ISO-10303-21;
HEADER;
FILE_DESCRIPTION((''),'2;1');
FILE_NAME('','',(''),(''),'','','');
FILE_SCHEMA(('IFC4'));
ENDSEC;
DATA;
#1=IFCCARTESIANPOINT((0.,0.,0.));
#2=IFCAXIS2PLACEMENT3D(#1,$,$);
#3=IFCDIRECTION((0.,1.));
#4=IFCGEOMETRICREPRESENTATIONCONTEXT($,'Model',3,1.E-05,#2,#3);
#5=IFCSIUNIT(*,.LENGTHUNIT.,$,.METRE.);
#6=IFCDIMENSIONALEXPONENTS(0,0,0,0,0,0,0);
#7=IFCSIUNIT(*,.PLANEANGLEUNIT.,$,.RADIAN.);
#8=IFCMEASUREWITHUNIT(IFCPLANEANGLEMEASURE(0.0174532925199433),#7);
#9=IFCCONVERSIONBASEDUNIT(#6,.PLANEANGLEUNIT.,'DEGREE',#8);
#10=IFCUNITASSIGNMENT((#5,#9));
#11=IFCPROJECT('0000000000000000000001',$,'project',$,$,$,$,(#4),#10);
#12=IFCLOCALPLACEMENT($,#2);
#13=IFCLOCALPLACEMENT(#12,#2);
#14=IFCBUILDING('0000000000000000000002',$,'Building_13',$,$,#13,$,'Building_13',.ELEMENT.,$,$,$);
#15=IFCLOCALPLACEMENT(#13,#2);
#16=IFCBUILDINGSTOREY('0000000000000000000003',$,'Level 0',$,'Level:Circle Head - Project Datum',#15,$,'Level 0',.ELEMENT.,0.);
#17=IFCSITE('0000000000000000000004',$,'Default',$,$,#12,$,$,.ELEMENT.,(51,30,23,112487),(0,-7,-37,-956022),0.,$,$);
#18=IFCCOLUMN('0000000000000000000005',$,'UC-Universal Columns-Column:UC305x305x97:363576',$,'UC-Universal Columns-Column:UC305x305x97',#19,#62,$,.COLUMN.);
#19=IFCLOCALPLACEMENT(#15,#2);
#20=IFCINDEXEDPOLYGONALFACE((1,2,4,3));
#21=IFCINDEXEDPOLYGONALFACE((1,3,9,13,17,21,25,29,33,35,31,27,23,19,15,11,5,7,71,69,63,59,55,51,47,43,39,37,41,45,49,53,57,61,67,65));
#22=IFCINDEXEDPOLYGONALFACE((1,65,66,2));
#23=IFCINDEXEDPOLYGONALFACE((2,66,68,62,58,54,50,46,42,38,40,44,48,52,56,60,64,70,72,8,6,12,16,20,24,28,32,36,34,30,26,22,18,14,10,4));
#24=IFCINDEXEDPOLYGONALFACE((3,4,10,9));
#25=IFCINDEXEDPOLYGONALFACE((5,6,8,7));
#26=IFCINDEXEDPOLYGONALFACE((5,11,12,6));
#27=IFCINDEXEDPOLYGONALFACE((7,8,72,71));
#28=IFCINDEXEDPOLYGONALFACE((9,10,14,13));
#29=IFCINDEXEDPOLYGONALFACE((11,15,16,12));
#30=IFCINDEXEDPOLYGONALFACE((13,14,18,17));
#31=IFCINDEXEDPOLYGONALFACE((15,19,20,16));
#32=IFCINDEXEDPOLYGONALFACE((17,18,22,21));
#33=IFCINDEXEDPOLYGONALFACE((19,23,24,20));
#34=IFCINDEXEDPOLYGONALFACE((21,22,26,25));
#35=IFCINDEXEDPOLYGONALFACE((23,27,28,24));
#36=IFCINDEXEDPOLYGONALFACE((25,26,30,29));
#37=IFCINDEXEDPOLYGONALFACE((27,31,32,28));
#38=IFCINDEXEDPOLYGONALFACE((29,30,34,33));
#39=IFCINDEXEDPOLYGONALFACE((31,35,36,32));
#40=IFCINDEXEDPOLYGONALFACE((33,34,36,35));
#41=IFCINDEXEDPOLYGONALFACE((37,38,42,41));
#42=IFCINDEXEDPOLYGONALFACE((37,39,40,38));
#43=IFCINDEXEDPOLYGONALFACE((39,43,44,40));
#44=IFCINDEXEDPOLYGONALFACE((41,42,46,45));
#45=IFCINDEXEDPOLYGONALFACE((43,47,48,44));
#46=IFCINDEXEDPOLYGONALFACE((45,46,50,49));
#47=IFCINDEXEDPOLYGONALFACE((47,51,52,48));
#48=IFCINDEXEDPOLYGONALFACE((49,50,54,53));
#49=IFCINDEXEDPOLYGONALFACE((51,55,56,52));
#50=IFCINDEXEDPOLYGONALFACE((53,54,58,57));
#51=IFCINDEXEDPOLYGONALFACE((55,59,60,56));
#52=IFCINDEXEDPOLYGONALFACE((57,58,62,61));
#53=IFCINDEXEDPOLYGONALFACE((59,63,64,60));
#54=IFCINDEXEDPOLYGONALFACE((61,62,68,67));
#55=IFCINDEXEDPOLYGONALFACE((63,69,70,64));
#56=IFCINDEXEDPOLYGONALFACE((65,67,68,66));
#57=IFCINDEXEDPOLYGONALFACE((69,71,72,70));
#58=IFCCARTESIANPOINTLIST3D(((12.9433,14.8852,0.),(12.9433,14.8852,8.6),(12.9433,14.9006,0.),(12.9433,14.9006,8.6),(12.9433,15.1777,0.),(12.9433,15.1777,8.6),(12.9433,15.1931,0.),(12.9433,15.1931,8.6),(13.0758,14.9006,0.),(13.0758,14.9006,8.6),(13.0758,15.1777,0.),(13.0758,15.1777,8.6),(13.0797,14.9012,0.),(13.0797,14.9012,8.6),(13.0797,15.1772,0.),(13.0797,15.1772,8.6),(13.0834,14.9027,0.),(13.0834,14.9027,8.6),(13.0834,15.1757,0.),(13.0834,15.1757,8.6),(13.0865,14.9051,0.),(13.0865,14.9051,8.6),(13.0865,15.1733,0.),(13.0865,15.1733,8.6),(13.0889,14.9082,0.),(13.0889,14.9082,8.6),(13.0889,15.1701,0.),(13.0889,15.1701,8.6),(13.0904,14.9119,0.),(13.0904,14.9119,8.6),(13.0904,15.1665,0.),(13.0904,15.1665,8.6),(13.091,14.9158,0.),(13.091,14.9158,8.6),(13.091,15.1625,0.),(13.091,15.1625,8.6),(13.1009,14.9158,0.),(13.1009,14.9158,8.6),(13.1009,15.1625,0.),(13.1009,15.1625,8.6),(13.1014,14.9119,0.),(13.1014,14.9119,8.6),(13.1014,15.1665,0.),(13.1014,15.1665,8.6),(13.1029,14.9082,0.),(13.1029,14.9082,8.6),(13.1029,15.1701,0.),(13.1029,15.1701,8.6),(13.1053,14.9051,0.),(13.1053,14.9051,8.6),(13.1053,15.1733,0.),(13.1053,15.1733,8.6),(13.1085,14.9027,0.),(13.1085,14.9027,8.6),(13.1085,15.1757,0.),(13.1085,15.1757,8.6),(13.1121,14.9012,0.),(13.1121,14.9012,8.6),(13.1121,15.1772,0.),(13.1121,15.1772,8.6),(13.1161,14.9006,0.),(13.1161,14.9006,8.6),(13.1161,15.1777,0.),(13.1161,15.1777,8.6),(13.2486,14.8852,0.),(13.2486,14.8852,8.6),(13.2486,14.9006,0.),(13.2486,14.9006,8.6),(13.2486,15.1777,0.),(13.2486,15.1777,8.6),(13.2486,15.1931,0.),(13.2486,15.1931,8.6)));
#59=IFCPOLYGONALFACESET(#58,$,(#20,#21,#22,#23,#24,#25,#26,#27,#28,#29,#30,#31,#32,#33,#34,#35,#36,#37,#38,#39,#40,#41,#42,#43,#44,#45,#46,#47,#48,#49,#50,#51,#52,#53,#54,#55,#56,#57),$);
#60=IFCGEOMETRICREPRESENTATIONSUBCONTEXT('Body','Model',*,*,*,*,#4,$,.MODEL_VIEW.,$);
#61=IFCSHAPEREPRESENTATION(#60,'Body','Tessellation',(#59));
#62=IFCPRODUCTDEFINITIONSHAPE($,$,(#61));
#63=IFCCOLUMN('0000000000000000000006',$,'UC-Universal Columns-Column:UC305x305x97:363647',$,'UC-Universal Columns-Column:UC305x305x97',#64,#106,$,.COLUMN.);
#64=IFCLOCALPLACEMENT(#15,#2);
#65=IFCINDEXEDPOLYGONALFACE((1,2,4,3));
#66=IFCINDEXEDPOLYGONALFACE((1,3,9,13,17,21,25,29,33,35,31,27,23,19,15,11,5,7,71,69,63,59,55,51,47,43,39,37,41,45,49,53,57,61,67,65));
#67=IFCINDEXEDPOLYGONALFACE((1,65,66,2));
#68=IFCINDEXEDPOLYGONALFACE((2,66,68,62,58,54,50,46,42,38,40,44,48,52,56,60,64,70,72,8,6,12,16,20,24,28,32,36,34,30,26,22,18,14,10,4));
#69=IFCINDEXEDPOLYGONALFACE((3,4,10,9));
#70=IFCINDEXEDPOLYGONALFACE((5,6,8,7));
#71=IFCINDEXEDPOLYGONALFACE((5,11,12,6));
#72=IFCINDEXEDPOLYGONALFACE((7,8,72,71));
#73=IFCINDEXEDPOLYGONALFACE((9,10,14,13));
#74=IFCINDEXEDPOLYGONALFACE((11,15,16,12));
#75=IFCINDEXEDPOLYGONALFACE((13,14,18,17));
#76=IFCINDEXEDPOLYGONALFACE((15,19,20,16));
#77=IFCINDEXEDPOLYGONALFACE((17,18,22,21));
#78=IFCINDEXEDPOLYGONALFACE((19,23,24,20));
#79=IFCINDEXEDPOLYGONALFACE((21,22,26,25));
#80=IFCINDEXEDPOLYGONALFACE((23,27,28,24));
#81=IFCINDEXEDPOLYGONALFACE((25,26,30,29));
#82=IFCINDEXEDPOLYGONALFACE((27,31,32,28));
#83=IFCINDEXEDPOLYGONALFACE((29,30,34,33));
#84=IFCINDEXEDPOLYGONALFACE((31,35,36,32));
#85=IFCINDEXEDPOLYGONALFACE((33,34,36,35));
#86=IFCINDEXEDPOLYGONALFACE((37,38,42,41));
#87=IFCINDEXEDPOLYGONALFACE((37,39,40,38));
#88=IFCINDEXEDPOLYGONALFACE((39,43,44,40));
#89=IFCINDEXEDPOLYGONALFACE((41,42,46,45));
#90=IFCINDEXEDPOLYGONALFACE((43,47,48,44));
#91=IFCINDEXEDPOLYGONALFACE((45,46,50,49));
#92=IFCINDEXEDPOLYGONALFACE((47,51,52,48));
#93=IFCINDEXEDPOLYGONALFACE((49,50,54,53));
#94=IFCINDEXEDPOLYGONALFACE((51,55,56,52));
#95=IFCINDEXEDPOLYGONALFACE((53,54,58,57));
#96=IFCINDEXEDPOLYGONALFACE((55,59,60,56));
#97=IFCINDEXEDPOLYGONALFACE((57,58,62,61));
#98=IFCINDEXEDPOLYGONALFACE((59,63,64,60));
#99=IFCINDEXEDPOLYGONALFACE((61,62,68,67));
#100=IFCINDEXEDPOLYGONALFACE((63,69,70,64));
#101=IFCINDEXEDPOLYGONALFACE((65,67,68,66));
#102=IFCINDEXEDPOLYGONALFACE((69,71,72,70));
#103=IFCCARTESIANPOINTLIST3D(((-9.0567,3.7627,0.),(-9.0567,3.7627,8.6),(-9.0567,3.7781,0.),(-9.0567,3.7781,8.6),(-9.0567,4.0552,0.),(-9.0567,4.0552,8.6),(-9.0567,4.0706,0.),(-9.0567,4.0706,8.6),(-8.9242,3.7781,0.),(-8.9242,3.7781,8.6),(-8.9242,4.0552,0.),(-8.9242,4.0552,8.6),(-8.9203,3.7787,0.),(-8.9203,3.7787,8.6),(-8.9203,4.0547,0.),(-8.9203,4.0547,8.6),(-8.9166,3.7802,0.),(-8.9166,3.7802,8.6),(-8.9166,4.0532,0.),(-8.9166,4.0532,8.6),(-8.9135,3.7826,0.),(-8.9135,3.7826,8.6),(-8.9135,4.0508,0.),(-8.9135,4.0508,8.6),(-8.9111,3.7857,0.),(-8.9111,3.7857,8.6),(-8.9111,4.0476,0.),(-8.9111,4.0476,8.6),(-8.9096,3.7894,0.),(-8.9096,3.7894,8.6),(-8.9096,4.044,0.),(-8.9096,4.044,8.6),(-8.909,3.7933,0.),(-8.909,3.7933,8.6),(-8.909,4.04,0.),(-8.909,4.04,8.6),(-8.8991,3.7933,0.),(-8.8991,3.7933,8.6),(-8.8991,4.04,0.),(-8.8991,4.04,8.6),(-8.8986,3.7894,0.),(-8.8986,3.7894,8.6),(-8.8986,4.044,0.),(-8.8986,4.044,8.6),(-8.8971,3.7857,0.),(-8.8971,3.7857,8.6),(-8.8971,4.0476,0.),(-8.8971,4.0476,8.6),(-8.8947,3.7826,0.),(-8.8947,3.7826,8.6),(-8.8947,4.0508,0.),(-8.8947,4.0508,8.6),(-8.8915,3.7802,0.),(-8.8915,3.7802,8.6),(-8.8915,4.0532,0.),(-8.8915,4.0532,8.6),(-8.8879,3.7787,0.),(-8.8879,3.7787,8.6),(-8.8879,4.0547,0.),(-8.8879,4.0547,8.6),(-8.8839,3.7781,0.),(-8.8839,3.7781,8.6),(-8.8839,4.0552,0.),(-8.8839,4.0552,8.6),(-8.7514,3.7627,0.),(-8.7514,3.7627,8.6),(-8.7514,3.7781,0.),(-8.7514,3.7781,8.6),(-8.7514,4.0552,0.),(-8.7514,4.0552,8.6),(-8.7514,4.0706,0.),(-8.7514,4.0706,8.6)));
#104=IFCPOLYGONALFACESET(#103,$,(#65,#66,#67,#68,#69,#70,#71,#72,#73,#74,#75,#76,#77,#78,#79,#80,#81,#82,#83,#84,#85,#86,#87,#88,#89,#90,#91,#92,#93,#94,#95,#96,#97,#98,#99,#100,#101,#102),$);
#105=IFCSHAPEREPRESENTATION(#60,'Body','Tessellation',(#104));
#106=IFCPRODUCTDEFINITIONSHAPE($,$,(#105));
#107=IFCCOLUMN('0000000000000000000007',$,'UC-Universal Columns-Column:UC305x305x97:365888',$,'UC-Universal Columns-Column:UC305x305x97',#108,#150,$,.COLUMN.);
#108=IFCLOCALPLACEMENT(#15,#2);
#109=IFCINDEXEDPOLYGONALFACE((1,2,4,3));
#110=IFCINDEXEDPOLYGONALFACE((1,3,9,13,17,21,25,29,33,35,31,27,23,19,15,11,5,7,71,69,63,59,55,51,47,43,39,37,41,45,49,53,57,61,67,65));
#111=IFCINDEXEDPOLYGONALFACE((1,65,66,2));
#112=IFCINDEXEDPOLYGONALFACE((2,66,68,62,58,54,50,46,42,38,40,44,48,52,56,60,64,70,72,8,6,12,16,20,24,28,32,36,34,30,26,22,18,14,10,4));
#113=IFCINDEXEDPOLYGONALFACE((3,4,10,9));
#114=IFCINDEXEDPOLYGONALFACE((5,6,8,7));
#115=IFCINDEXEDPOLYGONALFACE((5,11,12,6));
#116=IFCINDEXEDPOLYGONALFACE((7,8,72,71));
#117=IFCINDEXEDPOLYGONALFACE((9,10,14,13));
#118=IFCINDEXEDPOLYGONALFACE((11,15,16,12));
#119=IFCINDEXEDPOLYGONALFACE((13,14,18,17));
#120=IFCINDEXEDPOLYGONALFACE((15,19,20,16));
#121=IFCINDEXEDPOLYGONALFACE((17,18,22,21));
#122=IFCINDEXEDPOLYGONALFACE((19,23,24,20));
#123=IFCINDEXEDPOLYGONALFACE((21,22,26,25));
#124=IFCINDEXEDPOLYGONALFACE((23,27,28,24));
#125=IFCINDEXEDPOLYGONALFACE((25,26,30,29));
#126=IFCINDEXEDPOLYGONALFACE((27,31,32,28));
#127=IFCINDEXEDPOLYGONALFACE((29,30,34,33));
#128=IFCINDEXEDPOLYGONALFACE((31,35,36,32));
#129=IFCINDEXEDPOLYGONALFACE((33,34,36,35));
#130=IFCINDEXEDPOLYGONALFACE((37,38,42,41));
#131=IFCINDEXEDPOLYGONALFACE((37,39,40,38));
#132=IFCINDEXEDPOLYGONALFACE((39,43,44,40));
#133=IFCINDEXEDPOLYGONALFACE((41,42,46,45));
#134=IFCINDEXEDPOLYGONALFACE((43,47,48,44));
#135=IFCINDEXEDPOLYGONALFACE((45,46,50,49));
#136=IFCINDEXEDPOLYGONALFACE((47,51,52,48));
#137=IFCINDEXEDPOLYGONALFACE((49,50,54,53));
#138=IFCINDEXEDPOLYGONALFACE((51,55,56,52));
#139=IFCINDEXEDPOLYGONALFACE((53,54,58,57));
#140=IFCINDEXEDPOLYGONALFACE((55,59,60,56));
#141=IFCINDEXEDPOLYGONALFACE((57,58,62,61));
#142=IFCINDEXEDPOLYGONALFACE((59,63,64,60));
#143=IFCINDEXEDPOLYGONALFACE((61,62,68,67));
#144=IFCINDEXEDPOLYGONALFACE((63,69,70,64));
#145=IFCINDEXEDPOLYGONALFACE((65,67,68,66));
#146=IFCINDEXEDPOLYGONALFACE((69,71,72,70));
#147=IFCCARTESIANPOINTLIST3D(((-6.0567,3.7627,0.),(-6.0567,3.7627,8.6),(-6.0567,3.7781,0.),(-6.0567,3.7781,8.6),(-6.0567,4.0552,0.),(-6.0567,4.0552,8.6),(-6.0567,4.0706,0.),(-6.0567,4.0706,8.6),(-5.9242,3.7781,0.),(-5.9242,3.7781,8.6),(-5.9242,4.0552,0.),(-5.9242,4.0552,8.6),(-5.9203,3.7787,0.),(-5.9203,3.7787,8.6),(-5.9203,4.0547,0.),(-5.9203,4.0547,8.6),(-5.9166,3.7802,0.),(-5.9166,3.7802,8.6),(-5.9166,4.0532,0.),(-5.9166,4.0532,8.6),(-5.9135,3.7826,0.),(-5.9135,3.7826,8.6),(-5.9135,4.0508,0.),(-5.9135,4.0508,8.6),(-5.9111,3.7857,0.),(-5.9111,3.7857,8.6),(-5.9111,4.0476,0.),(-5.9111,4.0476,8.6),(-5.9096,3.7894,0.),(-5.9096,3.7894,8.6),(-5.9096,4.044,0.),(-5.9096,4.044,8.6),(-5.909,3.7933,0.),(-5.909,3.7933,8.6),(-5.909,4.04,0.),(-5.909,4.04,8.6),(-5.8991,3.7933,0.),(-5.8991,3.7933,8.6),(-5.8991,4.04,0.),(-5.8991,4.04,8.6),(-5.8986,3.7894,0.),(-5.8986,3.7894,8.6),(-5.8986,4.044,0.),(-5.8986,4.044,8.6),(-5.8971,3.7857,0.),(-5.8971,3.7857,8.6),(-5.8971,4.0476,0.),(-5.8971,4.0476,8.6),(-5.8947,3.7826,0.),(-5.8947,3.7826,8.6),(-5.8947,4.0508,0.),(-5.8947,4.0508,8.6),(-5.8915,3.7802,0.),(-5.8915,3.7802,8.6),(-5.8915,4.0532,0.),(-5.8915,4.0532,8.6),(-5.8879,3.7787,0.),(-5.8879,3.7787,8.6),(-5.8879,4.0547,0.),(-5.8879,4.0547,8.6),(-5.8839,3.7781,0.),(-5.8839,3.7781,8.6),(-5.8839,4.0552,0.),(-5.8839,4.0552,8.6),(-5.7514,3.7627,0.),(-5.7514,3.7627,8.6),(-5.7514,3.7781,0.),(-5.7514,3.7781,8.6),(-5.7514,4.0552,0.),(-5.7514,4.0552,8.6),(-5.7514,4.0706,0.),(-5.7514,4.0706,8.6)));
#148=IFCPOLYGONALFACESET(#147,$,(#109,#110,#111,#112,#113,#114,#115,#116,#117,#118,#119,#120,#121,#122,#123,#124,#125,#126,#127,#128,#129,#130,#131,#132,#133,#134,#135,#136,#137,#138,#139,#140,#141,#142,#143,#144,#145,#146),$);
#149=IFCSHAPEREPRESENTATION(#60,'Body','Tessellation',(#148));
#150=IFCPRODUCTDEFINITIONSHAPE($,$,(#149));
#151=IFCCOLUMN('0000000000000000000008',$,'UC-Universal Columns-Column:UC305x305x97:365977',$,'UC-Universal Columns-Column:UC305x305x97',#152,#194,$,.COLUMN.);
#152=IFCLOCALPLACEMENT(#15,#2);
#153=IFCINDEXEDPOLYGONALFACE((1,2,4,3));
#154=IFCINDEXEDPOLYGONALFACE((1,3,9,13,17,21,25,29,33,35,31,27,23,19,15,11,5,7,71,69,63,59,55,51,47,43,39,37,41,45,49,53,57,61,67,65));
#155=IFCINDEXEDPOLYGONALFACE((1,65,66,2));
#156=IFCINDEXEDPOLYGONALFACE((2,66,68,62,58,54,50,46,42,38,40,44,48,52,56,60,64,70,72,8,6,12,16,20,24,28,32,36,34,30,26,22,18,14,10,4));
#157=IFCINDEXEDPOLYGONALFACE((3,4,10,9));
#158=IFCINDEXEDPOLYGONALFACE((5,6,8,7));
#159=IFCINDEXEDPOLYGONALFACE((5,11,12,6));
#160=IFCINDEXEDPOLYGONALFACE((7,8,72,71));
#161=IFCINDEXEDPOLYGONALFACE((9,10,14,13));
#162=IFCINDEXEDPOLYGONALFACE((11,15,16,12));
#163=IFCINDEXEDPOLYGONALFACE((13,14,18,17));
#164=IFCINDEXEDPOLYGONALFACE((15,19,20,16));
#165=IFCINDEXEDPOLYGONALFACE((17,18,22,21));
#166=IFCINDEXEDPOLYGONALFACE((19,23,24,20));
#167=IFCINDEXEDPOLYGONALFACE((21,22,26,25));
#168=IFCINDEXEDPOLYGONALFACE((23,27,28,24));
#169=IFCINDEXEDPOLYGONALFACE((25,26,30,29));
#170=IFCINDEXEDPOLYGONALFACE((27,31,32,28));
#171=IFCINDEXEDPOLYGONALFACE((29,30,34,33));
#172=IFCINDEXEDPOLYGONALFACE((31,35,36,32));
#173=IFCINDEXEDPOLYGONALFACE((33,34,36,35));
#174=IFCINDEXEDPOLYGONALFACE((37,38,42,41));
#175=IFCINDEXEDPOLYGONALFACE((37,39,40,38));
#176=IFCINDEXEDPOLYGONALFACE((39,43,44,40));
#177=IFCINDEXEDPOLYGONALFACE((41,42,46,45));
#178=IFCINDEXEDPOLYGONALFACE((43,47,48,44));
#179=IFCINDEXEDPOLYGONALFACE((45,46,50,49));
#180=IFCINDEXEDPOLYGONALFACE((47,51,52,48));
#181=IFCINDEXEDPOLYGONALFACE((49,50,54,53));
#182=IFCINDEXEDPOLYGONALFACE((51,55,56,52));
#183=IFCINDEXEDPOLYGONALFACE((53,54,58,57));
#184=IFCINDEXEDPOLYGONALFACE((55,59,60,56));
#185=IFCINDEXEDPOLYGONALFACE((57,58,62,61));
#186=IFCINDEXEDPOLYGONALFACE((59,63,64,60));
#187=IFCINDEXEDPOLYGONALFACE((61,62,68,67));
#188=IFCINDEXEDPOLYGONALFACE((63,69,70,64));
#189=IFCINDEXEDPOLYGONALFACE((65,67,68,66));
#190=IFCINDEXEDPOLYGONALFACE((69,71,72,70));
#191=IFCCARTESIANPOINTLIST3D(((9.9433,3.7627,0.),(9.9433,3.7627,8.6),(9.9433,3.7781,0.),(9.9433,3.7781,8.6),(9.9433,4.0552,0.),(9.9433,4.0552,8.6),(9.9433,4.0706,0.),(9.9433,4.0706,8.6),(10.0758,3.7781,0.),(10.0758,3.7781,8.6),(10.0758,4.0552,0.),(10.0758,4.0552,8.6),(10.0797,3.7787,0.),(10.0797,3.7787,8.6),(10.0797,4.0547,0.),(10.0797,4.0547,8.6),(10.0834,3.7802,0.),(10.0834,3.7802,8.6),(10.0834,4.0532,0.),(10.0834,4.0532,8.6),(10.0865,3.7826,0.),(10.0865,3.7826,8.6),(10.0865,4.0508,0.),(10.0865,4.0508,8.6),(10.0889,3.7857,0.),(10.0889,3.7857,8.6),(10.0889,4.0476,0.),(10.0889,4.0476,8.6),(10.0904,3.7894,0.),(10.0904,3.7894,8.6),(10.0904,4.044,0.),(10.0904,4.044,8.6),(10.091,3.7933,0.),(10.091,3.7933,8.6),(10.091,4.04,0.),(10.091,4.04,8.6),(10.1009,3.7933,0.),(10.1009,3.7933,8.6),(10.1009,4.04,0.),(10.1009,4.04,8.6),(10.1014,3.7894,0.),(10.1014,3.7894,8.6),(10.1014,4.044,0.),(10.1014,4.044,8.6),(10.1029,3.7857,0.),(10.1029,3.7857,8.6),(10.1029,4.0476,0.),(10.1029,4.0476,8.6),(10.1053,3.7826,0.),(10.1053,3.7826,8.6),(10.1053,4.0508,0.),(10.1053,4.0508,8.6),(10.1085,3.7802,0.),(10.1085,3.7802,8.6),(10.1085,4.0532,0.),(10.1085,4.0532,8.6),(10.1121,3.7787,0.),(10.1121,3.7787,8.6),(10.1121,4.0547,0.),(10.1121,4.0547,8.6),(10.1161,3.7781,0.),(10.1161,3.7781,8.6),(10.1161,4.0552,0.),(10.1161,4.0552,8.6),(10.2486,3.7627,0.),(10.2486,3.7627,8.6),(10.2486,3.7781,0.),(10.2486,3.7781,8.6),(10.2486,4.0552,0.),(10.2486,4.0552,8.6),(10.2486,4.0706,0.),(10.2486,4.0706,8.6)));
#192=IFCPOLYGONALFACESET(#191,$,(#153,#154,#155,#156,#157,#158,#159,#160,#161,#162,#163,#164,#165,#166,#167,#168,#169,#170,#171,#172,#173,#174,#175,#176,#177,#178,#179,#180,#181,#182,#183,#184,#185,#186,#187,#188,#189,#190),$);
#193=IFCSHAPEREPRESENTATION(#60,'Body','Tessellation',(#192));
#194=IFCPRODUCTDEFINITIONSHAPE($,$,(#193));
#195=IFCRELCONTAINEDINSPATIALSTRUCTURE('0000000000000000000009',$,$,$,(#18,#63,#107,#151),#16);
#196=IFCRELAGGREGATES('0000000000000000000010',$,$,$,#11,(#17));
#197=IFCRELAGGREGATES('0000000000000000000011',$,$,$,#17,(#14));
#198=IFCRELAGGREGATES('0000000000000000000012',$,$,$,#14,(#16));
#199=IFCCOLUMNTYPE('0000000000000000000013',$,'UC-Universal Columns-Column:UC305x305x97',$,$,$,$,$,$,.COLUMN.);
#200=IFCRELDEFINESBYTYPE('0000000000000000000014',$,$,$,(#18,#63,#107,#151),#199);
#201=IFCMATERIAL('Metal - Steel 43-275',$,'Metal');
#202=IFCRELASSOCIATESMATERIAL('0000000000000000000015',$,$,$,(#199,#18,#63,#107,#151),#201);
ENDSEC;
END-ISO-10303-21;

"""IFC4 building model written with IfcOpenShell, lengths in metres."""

from ifc_helpers import new_model, entity, si_unit, converted_unit, direction, frame, origin, place, context, subcontext, project, spatial, line, arc, indexed_curve, outline, extrude, source, transform, mapped, material, type_object, type_shapes, element, save


model = new_model("IFC4")

# Units and contexts
model_context = context("Model", 3, precision=1e-05, world=origin(), true_north=direction((0.0, 1.0)))
body_context = subcontext(model_context, "Body", "Model", "MODEL_VIEW")
ifc_project = project(units=[si_unit("LENGTHUNIT", "METRE"), converted_unit("PLANEANGLEUNIT", "DEGREE", entity("IfcPlaneAngleMeasure", 0.0174532925199433), si_unit("PLANEANGLEUNIT", "RADIAN"), dimensions=[0, 0, 0, 0, 0, 0, 0])], contexts=[model_context])

# Site, building, storey
site_placement = place(None, origin())
site = spatial("IfcSite", under=ifc_project, at=site_placement, Name="Default", CompositionType="ELEMENT", RefLatitude=(51, 30, 23, 112487), RefLongitude=(0, -7, -37, -956022), RefElevation=0.0)
building_placement = place(site_placement, origin())
building = spatial("IfcBuilding", under=site, at=building_placement, Name="Building_13", LongName="Building_13", CompositionType="ELEMENT")
storey_placement = place(building_placement, origin())
storey = spatial("IfcBuildingStorey", under=building, at=storey_placement, Name="Level 0", ObjectType="Level:Circle Head - Project Datum", LongName="Level 0", CompositionType="ELEMENT", Elevation=0.0)

# Columns
ifc_material_1 = material(Name="Metal - Steel 43-275", Category="Metal")
column_type_1 = type_object("IfcColumnType", Name="UC-Universal Columns-Column:UC305x305x97", PredefinedType="COLUMN", material=ifc_material_1)
shared_shape_1 = source(origin(), body_context, "Body", "SweptSolid", [
    extrude(outline(indexed_curve([(-0.1527, -0.154), (0.1527, -0.154), (0.1527, -0.1386), (0.0202, -0.1386), (0.0094, -0.1341), (0.0049, -0.1234), (0.0049, 0.1234), (0.0094, 0.1341), (0.0202, 0.1386), (0.1527, 0.1386), (0.1527, 0.154), (-0.1527, 0.154), (-0.1527, 0.1386), (-0.0202, 0.1386), (-0.0094, 0.1341), (-0.005, 0.1234), (-0.005, -0.1234), (-0.0094, -0.1341), (-0.0202, -0.1386), (-0.1527, -0.1386)], segments=[line(1, 2, 3, 4), arc(4, 5, 6), line(6, 7), arc(7, 8, 9), line(9, 10, 11, 12, 13, 14), arc(14, 15, 16), line(16, 17), arc(17, 18, 19), line(19, 20, 1)], self_intersect=False)), frame((0.0, 0.0, 0.0), z_axis=(0.0, 0.0, 1.0), x_axis=(-1.0, 0.0, 0.0)), (0.0, 0.0, 1.0), 8.6),
])
type_shapes(column_type_1, [shared_shape_1])
for number, where, name in (
    (1, (13.0959, 15.0392, 0.0), "UC-Universal Columns-Column:UC305x305x97:363576"),
    (2, (-8.9041, 3.9167, 0.0), "UC-Universal Columns-Column:UC305x305x97:363647"),
    (3, (-5.9041, 3.9167, 0.0), "UC-Universal Columns-Column:UC305x305x97:365888"),
    (4, (10.0959, 3.9167, 0.0), "UC-Universal Columns-Column:UC305x305x97:365977"),
):
    element("IfcColumn", number, at=place(storey_placement, frame(where)), inside=storey, type_object=column_type_1, material=ifc_material_1, Name=name, ObjectType="UC-Universal Columns-Column:UC305x305x97", PredefinedType="COLUMN", context=body_context, shape_type="MappedRepresentation", body=[
        mapped(shared_shape_1, transform((0.0, 0.0, 0.0), scale=1.0)),
    ])

save(model, "model.ifc")
